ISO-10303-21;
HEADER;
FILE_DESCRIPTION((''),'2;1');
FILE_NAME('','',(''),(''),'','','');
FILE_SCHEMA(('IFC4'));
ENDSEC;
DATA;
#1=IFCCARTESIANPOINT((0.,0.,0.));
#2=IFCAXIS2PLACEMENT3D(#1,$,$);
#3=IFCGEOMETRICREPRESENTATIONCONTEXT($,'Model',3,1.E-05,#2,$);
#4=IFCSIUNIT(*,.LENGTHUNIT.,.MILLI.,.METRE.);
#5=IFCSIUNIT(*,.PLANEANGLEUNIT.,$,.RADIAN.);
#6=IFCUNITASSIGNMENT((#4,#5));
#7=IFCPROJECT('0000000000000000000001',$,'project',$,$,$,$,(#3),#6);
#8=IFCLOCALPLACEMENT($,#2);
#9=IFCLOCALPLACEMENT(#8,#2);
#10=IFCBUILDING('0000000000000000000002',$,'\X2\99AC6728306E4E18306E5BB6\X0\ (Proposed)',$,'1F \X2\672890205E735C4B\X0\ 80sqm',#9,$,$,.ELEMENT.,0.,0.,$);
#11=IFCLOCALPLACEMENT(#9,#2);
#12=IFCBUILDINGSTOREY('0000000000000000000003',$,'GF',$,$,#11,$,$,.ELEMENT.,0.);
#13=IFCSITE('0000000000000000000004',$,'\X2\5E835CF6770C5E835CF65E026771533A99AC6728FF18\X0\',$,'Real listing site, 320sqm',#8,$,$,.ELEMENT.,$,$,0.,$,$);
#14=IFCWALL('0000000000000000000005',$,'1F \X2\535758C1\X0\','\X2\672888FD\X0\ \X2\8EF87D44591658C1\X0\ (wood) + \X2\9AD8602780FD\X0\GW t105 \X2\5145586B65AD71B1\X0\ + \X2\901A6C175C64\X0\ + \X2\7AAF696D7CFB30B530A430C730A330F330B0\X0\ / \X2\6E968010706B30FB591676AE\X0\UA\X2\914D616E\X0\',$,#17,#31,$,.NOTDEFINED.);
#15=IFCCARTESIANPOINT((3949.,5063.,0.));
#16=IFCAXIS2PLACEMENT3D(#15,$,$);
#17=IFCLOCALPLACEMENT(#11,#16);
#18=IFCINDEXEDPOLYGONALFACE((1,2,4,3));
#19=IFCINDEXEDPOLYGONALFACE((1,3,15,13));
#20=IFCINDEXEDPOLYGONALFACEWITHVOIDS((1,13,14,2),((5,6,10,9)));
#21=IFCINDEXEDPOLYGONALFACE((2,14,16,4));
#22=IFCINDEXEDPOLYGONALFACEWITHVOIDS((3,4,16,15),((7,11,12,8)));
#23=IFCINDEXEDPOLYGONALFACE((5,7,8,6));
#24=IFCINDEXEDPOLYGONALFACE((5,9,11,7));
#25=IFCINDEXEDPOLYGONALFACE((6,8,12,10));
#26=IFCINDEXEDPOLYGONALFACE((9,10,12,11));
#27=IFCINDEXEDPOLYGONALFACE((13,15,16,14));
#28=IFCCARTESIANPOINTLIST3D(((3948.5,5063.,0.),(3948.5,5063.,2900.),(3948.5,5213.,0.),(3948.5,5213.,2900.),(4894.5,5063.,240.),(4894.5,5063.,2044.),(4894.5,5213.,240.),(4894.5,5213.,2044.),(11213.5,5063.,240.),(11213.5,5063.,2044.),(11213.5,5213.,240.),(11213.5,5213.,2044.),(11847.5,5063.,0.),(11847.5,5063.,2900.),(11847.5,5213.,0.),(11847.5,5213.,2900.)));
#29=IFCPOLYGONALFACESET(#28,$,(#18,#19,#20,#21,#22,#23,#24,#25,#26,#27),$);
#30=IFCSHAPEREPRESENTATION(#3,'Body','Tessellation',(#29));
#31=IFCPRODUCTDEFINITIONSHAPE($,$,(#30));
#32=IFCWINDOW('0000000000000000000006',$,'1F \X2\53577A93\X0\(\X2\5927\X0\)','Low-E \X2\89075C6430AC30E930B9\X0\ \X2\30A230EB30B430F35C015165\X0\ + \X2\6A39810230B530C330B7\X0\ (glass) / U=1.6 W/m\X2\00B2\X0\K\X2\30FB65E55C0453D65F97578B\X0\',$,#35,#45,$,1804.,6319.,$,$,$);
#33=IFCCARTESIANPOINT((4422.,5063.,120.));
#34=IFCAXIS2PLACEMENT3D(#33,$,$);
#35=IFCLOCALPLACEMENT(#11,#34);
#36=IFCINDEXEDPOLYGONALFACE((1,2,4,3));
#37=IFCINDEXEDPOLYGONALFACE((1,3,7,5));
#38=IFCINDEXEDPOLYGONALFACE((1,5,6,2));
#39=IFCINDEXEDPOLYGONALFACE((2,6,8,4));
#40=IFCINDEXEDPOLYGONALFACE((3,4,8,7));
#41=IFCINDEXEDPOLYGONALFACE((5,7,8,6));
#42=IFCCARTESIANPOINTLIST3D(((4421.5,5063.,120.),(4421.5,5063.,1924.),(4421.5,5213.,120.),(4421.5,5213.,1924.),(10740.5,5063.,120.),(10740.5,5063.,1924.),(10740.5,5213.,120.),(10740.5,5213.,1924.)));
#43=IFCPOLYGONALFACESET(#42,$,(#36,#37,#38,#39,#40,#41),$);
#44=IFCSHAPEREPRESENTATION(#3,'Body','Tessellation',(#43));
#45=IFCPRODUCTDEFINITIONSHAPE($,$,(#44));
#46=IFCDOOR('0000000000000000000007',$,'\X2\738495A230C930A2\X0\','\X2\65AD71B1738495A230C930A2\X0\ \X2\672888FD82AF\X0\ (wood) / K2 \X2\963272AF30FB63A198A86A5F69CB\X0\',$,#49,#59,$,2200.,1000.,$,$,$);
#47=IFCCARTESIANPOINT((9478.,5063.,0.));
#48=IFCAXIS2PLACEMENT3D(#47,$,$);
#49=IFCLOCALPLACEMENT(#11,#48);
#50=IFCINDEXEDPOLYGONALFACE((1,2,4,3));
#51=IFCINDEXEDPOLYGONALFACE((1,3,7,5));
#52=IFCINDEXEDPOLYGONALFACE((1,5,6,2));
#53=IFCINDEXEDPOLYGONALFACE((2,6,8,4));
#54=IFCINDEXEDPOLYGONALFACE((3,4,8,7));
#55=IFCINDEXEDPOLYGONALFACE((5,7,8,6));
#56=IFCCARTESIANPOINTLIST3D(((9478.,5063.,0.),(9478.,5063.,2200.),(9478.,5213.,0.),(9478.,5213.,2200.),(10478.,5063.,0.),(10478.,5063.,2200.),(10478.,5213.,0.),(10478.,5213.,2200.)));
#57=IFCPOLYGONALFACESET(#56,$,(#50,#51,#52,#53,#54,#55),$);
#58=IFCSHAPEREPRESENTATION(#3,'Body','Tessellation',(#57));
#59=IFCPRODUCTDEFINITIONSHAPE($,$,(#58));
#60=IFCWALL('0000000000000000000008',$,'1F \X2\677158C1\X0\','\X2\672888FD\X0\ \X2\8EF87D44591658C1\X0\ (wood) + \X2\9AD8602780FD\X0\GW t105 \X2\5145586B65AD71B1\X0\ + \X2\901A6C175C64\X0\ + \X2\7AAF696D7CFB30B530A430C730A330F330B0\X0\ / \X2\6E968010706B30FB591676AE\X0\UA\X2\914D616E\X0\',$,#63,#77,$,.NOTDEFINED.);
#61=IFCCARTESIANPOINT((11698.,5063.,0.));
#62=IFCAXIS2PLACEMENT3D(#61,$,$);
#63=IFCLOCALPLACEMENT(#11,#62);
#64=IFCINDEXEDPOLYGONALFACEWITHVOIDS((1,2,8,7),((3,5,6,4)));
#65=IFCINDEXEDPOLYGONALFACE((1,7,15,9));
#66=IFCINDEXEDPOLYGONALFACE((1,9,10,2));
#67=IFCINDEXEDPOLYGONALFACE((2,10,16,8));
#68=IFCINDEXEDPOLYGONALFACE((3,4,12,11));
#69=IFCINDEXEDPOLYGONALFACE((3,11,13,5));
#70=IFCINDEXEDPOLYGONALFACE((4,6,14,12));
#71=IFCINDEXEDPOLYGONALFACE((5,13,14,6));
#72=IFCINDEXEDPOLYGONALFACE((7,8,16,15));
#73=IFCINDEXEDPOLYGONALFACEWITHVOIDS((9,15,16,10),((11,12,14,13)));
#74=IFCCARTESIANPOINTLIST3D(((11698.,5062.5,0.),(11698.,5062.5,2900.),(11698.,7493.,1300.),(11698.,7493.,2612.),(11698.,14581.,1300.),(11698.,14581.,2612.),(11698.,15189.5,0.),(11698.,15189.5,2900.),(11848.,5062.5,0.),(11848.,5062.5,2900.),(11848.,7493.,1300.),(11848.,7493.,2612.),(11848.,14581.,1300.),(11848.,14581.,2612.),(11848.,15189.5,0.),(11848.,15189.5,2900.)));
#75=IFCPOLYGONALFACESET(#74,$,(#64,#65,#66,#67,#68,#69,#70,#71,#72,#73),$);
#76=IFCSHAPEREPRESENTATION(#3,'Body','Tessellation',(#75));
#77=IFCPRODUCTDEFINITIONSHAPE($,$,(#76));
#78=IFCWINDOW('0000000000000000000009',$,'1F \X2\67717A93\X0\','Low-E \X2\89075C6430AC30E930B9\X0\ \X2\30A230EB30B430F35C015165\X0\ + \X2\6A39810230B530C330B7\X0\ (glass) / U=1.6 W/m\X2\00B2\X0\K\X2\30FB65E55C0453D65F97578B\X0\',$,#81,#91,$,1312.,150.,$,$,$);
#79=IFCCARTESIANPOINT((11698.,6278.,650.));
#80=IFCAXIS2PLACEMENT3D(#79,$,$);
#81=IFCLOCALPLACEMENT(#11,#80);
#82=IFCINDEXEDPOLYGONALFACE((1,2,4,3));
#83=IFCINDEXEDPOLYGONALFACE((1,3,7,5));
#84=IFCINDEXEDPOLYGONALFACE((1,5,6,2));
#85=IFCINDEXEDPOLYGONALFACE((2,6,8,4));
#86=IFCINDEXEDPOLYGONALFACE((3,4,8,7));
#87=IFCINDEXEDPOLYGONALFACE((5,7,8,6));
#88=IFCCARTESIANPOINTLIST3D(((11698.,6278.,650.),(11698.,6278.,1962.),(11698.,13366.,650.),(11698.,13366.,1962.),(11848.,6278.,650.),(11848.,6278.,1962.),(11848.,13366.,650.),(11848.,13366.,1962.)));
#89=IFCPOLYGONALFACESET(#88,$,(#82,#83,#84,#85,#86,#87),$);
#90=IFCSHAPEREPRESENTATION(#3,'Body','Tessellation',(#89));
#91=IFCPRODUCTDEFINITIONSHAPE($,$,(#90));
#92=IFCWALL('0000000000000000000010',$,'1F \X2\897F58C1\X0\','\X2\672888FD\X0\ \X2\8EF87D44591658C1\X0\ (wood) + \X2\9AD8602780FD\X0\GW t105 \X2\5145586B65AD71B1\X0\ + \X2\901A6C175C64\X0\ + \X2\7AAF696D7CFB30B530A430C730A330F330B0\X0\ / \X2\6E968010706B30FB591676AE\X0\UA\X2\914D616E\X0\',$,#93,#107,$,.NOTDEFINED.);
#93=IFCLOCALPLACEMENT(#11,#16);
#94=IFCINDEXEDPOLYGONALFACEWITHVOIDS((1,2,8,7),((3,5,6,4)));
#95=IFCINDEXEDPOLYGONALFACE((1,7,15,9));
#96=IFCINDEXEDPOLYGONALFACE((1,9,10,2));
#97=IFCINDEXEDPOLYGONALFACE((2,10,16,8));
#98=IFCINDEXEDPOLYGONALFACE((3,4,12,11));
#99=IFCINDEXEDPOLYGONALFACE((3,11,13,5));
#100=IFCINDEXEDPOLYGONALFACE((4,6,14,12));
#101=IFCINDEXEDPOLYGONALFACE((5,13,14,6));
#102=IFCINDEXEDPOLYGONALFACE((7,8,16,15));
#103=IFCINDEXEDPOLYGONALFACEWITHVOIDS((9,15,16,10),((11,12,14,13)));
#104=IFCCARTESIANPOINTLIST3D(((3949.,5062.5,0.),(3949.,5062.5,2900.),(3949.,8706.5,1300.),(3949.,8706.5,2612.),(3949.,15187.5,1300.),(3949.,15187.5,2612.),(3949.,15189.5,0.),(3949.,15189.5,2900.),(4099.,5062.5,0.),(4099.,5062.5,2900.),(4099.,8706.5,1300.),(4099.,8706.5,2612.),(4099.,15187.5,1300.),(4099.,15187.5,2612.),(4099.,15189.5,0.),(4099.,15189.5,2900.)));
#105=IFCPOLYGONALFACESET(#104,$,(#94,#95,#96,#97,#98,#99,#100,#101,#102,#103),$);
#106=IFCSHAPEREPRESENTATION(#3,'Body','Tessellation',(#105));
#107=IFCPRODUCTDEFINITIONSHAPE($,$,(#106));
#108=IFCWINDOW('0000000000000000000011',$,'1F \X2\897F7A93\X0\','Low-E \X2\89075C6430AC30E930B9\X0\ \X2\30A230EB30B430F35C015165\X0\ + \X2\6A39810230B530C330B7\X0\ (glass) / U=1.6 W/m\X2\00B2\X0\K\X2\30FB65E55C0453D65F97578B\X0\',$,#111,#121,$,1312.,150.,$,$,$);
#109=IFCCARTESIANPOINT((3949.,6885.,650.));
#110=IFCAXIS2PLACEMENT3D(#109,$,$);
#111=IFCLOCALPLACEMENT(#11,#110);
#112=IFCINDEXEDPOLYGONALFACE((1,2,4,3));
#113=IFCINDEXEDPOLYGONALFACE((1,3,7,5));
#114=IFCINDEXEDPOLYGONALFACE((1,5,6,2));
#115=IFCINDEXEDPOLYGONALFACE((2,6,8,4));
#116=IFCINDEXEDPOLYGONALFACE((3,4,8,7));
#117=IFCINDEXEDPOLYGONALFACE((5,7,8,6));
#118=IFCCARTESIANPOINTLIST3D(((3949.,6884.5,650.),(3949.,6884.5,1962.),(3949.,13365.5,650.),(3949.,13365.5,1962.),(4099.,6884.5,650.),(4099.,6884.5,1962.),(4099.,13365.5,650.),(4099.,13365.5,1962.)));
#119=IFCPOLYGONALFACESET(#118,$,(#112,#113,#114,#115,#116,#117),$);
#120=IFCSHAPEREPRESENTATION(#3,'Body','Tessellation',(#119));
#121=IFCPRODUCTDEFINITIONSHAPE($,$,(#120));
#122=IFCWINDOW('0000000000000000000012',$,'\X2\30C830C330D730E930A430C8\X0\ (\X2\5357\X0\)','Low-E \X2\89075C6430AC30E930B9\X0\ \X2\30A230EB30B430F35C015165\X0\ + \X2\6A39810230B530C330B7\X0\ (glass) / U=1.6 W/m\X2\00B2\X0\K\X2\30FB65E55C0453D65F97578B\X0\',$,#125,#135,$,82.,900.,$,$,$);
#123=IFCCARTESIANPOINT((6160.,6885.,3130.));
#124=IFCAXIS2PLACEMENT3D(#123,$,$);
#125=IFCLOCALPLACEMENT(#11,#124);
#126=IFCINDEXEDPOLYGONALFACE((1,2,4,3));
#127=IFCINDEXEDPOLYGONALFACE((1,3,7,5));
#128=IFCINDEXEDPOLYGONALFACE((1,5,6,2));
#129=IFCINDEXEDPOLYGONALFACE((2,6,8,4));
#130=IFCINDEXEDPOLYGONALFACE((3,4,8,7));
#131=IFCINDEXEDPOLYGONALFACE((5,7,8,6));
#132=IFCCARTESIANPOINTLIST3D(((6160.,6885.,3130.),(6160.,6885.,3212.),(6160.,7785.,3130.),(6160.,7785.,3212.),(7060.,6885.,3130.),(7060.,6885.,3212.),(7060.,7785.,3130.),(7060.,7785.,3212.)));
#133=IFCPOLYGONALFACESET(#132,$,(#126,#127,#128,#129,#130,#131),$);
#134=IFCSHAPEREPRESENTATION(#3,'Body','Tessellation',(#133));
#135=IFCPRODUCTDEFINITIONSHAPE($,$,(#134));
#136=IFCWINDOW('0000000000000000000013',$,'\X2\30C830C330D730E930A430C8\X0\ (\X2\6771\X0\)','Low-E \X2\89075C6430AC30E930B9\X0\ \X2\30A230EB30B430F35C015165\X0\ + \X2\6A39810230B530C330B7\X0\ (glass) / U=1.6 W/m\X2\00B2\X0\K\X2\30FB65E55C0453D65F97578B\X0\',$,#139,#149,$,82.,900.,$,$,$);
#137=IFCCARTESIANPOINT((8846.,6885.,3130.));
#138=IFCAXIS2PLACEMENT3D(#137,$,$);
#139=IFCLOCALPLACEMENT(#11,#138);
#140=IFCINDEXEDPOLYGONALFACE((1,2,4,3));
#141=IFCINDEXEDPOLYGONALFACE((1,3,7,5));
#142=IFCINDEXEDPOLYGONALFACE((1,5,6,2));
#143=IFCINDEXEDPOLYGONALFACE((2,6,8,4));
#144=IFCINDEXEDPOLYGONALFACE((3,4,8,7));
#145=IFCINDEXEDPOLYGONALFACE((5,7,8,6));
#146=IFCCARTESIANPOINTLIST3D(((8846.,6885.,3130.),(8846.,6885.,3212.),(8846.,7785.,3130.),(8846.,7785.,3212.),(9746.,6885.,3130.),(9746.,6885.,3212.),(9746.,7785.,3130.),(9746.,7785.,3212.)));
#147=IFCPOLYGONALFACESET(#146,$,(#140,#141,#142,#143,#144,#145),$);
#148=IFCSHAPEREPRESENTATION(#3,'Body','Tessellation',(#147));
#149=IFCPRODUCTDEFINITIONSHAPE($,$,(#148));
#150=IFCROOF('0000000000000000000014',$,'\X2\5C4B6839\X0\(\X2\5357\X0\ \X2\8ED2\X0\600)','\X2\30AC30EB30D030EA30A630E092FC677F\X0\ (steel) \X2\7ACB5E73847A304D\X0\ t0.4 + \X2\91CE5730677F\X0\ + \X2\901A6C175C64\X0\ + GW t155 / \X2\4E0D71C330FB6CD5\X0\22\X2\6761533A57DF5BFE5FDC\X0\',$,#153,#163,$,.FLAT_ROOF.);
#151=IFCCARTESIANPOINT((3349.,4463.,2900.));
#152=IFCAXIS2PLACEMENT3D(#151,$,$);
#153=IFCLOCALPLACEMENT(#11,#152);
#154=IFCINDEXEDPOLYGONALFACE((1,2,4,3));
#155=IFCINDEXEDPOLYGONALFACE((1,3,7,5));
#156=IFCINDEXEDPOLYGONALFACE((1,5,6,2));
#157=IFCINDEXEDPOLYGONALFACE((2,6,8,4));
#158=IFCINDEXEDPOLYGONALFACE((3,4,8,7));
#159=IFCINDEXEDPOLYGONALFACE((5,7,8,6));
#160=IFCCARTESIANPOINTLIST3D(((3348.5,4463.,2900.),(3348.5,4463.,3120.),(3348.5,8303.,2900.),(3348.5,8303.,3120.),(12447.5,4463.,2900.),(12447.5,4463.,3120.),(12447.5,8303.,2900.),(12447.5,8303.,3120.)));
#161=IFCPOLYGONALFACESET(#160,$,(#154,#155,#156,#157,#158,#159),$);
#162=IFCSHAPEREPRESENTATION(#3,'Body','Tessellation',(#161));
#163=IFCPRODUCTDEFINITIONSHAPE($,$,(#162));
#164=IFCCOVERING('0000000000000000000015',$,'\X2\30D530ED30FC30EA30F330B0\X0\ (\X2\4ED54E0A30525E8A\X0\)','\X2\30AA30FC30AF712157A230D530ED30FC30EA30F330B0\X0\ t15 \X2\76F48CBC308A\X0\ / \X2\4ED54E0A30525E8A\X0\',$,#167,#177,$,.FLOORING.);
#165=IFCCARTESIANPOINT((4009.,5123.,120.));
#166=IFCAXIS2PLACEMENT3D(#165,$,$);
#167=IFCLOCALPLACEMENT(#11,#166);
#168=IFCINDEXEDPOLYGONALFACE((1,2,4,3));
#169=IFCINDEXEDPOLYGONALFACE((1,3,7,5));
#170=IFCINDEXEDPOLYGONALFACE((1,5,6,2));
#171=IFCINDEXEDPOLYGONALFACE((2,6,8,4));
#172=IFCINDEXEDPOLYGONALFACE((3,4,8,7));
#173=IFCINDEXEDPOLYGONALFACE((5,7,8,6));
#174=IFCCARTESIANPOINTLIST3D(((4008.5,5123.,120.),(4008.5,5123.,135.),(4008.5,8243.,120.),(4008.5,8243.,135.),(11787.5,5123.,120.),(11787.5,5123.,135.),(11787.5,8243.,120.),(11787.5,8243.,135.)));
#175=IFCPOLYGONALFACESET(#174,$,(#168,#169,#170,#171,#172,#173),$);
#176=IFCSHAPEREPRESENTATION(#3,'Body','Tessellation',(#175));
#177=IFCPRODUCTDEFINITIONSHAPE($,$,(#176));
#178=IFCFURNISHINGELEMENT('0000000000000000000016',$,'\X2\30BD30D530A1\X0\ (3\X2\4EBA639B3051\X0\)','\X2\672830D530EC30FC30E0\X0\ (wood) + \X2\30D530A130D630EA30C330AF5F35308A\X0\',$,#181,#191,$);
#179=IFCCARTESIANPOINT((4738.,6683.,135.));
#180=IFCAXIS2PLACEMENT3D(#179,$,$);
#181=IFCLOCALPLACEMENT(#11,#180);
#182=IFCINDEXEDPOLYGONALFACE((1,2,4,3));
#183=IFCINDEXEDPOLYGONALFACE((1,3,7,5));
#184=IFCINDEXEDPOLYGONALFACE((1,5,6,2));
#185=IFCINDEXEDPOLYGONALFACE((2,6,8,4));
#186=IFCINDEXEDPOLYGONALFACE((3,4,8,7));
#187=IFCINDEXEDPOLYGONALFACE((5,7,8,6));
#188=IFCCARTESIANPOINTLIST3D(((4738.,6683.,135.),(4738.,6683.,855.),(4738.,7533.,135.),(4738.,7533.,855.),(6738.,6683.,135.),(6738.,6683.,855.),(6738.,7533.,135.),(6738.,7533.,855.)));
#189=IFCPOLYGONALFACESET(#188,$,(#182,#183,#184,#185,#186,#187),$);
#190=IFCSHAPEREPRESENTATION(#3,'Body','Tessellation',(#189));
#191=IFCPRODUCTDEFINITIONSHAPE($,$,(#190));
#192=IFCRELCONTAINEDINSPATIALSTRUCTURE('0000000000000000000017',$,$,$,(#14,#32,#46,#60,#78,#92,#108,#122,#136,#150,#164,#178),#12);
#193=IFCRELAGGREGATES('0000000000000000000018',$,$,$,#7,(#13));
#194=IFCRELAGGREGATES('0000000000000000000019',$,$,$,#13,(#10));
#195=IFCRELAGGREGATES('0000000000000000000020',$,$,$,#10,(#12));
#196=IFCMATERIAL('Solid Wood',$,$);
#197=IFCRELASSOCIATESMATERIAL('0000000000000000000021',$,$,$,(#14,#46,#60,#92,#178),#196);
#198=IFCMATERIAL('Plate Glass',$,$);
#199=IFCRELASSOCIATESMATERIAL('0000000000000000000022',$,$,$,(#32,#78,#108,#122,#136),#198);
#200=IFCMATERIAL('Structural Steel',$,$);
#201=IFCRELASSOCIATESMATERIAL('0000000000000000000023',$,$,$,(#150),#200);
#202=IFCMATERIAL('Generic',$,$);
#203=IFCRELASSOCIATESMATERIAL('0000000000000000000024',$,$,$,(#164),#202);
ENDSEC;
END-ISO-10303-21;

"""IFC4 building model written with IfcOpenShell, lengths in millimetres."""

from ifc_helpers import new_model, si_unit, frame, frame_2d, origin, place, context, project, spatial, rectangle, extrude, material, element, fill, save


model = new_model("IFC4")

# Units and contexts
model_context = context("Model", 3, precision=1e-05, world=origin())
ifc_project = project(units=[si_unit("LENGTHUNIT", "METRE", prefix="MILLI"), si_unit("PLANEANGLEUNIT", "RADIAN")], contexts=[model_context])

# Site, building, storey
site_placement = place(None, origin())
site = spatial("IfcSite", under=ifc_project, at=site_placement, Name="広島県広島市東区馬木８", ObjectType="Real listing site, 320sqm", CompositionType="ELEMENT", RefElevation=0.0)
building_placement = place(site_placement, origin())
building = spatial("IfcBuilding", under=site, at=building_placement, Name="馬木の丘の家 (Proposed)", ObjectType="1F 木造平屋 80sqm", CompositionType="ELEMENT", ElevationOfRefHeight=0.0, ElevationOfTerrain=0.0)
storey_placement = place(building_placement, origin())
storey = spatial("IfcBuildingStorey", under=building, at=storey_placement, Name="GF", CompositionType="ELEMENT", Elevation=0.0)

# Shared definitions
ifc_material_1 = material(Name="Solid Wood")

# Wall, openings, window, door
wall_1_placement = place(storey_placement, frame((3949.0, 5063.0, 0.0)))
wall_1 = element("IfcWall", 1, at=wall_1_placement, inside=storey, material=ifc_material_1, Name="1F 南壁", Description="木製 軸組外壁 (wood) + 高性能GW t105 充填断熱 + 通気層 + 窯業系サイディング / 準耐火・外皮UA配慮", PredefinedType="NOTDEFINED", context=model_context, shape_type="SweptSolid", body=[
    extrude(rectangle(XDim=7899.0, YDim=150.0, at=frame_2d((3949.0, 75.0))), frame((3949.0, 5063.0, 0.0)), (0.0, 0.0, 1.0), 2900.0),
])
opening_1_placement = place(storey_placement, frame((4422.0, 5063.0, 120.0)))
opening_1 = element("IfcOpeningElement", 2, at=opening_1_placement, cuts=wall_1, PredefinedType="NOTDEFINED", context=model_context, shape_type="SweptSolid", body=[
    extrude(rectangle(XDim=6319.0, YDim=150.0, at=frame_2d((3159.0, 75.0))), frame((4422.0, 5063.0, 120.0)), (0.0, 0.0, 1.0), 1804.0),
])
opening_2_placement = place(storey_placement, frame((9478.0, 5063.0, 0.0)))
opening_2 = element("IfcOpeningElement", 3, at=opening_2_placement, cuts=wall_1, PredefinedType="NOTDEFINED", context=model_context, shape_type="SweptSolid", body=[
    extrude(rectangle(XDim=1000.0, YDim=150.0, at=frame_2d((500.0, 75.0))), frame((9478.0, 5063.0, 0.0)), (0.0, 0.0, 1.0), 2200.0),
])
ifc_material_2 = material(Name="Plate Glass")
window_1_placement = place(storey_placement, frame((4422.0, 5063.0, 120.0)))
window_1 = element("IfcWindow", 4, at=window_1_placement, inside=storey, material=ifc_material_2, Name="1F 南窓(大)", Description="Low-E 複層ガラス アルゴン封入 + 樹脂サッシ (glass) / U=1.6 W/m²K・日射取得型", OverallHeight=1804.0, OverallWidth=6319.0, context=model_context, shape_type="SweptSolid", body=[
    extrude(rectangle(XDim=6319.0, YDim=150.0, at=frame_2d((3159.0, 75.0))), frame((4422.0, 5063.0, 120.0)), (0.0, 0.0, 1.0), 1804.0),
])
fill(opening_1, window_1)
door_placement = place(storey_placement, frame((9478.0, 5063.0, 0.0)))
door = element("IfcDoor", 5, at=door_placement, inside=storey, material=ifc_material_1, Name="玄関ドア", Description="断熱玄関ドア 木製芯 (wood) / K2 防犯・採風機構", OverallHeight=2200.0, OverallWidth=1000.0, context=model_context, shape_type="SweptSolid", body=[
    extrude(rectangle(XDim=1000.0, YDim=150.0, at=frame_2d((500.0, 75.0))), frame((9478.0, 5063.0, 0.0)), (0.0, 0.0, 1.0), 2200.0),
])
fill(opening_2, door)

# Walls, openings, windows
wall_2_placement = place(storey_placement, frame((11698.0, 5063.0, 0.0)))
wall_2 = element("IfcWall", 6, at=wall_2_placement, inside=storey, material=ifc_material_1, Name="1F 東壁", Description="木製 軸組外壁 (wood) + 高性能GW t105 充填断熱 + 通気層 + 窯業系サイディング / 準耐火・外皮UA配慮", PredefinedType="NOTDEFINED", context=model_context, shape_type="SweptSolid", body=[
    extrude(rectangle(XDim=150.0, YDim=10127.0, at=frame_2d((75.0, 5063.0))), frame((11698.0, 5063.0, 0.0)), (0.0, 0.0, 1.0), 2900.0),
])
opening_3_placement = place(storey_placement, frame((11698.0, 6278.0, 650.0)))
opening_3 = element("IfcOpeningElement", 7, at=opening_3_placement, cuts=wall_2, PredefinedType="NOTDEFINED", context=model_context, shape_type="SweptSolid", body=[
    extrude(rectangle(XDim=150.0, YDim=7088.0, at=frame_2d((75.0, 3544.0))), frame((11698.0, 6278.0, 650.0)), (0.0, 0.0, 1.0), 1312.0),
])
window_2_placement = place(storey_placement, frame((11698.0, 6278.0, 650.0)))
window_2 = element("IfcWindow", 8, at=window_2_placement, inside=storey, material=ifc_material_2, Name="1F 東窓", Description="Low-E 複層ガラス アルゴン封入 + 樹脂サッシ (glass) / U=1.6 W/m²K・日射取得型", OverallHeight=1312.0, OverallWidth=150.0, context=model_context, shape_type="SweptSolid", body=[
    extrude(rectangle(XDim=150.0, YDim=7088.0, at=frame_2d((75.0, 3544.0))), frame((11698.0, 6278.0, 650.0)), (0.0, 0.0, 1.0), 1312.0),
])
fill(opening_3, window_2)
wall_3_placement = place(storey_placement, frame((3949.0, 5063.0, 0.0)))
wall_3 = element("IfcWall", 9, at=wall_3_placement, inside=storey, material=ifc_material_1, Name="1F 西壁", Description="木製 軸組外壁 (wood) + 高性能GW t105 充填断熱 + 通気層 + 窯業系サイディング / 準耐火・外皮UA配慮", PredefinedType="NOTDEFINED", context=model_context, shape_type="SweptSolid", body=[
    extrude(rectangle(XDim=150.0, YDim=10127.0, at=frame_2d((75.0, 5063.0))), frame((3949.0, 5063.0, 0.0)), (0.0, 0.0, 1.0), 2900.0),
])
opening_4_placement = place(storey_placement, frame((3949.0, 6885.0, 650.0)))
opening_4 = element("IfcOpeningElement", 10, at=opening_4_placement, cuts=wall_3, PredefinedType="NOTDEFINED", context=model_context, shape_type="SweptSolid", body=[
    extrude(rectangle(XDim=150.0, YDim=6481.0, at=frame_2d((75.0, 3240.0))), frame((3949.0, 6885.0, 650.0)), (0.0, 0.0, 1.0), 1312.0),
])
window_3_placement = place(storey_placement, frame((3949.0, 6885.0, 650.0)))
window_3 = element("IfcWindow", 11, at=window_3_placement, inside=storey, material=ifc_material_2, Name="1F 西窓", Description="Low-E 複層ガラス アルゴン封入 + 樹脂サッシ (glass) / U=1.6 W/m²K・日射取得型", OverallHeight=1312.0, OverallWidth=150.0, context=model_context, shape_type="SweptSolid", body=[
    extrude(rectangle(XDim=150.0, YDim=6481.0, at=frame_2d((75.0, 3240.0))), frame((3949.0, 6885.0, 650.0)), (0.0, 0.0, 1.0), 1312.0),
])
fill(opening_4, window_3)

# Windows
window_4_placement = place(storey_placement, frame((6160.0, 6885.0, 3130.0)))
element("IfcWindow", 12, at=window_4_placement, inside=storey, material=ifc_material_2, Name="トップライト (南)", Description="Low-E 複層ガラス アルゴン封入 + 樹脂サッシ (glass) / U=1.6 W/m²K・日射取得型", OverallHeight=82.0, OverallWidth=900.0, context=model_context, shape_type="SweptSolid", body=[
    extrude(rectangle(XDim=900.0, YDim=900.0, at=frame_2d((450.0, 450.0))), frame((6160.0, 6885.0, 3130.0)), (0.0, 0.0, 1.0), 82.0),
])
window_5_placement = place(storey_placement, frame((8846.0, 6885.0, 3130.0)))
element("IfcWindow", 13, at=window_5_placement, inside=storey, material=ifc_material_2, Name="トップライト (東)", Description="Low-E 複層ガラス アルゴン封入 + 樹脂サッシ (glass) / U=1.6 W/m²K・日射取得型", OverallHeight=82.0, OverallWidth=900.0, context=model_context, shape_type="SweptSolid", body=[
    extrude(rectangle(XDim=900.0, YDim=900.0, at=frame_2d((450.0, 450.0))), frame((8846.0, 6885.0, 3130.0)), (0.0, 0.0, 1.0), 82.0),
])

# Roof
ifc_material_3 = material(Name="Structural Steel")
roof_placement = place(storey_placement, frame((3349.0, 4463.0, 2900.0)))
element("IfcRoof", 14, at=roof_placement, inside=storey, material=ifc_material_3, Name="屋根(南 軒600)", Description="ガルバリウム鋼板 (steel) 立平葺き t0.4 + 野地板 + 通気層 + GW t155 / 不燃・法22条区域対応", PredefinedType="FLAT_ROOF", context=model_context, shape_type="SweptSolid", body=[
    extrude(rectangle(XDim=9099.0, YDim=3840.0, at=frame_2d((4549.0, 1920.0))), frame((3349.0, 4463.0, 2900.0)), (0.0, 0.0, 1.0), 220.0),
])

# Covering
ifc_material_4 = material(Name="Generic")
covering_placement = place(storey_placement, frame((4009.0, 5123.0, 120.0)))
element("IfcCovering", 15, at=covering_placement, inside=storey, material=ifc_material_4, Name="フローリング (仕上げ床)", Description="オーク無垢フローリング t15 直貼り / 仕上げ床", PredefinedType="FLOORING", context=model_context, shape_type="SweptSolid", body=[
    extrude(rectangle(XDim=7779.0, YDim=3120.0, at=frame_2d((3889.0, 1560.0))), frame((4009.0, 5123.0, 120.0)), (0.0, 0.0, 1.0), 15.0),
])

# Furnishing element
furnishing_1_placement = place(storey_placement, frame((4738.0, 6683.0, 135.0)))
element("IfcFurnishingElement", 16, at=furnishing_1_placement, inside=storey, material=ifc_material_1, Name="ソファ (3人掛け)", Description="木フレーム (wood) + ファブリック張り", context=model_context, shape_type="SweptSolid", body=[
    extrude(rectangle(XDim=2000.0, YDim=850.0, at=frame_2d((1000.0, 425.0))), frame((4738.0, 6683.0, 135.0)), (0.0, 0.0, 1.0), 720.0),
])

save(model, "model.ifc")
